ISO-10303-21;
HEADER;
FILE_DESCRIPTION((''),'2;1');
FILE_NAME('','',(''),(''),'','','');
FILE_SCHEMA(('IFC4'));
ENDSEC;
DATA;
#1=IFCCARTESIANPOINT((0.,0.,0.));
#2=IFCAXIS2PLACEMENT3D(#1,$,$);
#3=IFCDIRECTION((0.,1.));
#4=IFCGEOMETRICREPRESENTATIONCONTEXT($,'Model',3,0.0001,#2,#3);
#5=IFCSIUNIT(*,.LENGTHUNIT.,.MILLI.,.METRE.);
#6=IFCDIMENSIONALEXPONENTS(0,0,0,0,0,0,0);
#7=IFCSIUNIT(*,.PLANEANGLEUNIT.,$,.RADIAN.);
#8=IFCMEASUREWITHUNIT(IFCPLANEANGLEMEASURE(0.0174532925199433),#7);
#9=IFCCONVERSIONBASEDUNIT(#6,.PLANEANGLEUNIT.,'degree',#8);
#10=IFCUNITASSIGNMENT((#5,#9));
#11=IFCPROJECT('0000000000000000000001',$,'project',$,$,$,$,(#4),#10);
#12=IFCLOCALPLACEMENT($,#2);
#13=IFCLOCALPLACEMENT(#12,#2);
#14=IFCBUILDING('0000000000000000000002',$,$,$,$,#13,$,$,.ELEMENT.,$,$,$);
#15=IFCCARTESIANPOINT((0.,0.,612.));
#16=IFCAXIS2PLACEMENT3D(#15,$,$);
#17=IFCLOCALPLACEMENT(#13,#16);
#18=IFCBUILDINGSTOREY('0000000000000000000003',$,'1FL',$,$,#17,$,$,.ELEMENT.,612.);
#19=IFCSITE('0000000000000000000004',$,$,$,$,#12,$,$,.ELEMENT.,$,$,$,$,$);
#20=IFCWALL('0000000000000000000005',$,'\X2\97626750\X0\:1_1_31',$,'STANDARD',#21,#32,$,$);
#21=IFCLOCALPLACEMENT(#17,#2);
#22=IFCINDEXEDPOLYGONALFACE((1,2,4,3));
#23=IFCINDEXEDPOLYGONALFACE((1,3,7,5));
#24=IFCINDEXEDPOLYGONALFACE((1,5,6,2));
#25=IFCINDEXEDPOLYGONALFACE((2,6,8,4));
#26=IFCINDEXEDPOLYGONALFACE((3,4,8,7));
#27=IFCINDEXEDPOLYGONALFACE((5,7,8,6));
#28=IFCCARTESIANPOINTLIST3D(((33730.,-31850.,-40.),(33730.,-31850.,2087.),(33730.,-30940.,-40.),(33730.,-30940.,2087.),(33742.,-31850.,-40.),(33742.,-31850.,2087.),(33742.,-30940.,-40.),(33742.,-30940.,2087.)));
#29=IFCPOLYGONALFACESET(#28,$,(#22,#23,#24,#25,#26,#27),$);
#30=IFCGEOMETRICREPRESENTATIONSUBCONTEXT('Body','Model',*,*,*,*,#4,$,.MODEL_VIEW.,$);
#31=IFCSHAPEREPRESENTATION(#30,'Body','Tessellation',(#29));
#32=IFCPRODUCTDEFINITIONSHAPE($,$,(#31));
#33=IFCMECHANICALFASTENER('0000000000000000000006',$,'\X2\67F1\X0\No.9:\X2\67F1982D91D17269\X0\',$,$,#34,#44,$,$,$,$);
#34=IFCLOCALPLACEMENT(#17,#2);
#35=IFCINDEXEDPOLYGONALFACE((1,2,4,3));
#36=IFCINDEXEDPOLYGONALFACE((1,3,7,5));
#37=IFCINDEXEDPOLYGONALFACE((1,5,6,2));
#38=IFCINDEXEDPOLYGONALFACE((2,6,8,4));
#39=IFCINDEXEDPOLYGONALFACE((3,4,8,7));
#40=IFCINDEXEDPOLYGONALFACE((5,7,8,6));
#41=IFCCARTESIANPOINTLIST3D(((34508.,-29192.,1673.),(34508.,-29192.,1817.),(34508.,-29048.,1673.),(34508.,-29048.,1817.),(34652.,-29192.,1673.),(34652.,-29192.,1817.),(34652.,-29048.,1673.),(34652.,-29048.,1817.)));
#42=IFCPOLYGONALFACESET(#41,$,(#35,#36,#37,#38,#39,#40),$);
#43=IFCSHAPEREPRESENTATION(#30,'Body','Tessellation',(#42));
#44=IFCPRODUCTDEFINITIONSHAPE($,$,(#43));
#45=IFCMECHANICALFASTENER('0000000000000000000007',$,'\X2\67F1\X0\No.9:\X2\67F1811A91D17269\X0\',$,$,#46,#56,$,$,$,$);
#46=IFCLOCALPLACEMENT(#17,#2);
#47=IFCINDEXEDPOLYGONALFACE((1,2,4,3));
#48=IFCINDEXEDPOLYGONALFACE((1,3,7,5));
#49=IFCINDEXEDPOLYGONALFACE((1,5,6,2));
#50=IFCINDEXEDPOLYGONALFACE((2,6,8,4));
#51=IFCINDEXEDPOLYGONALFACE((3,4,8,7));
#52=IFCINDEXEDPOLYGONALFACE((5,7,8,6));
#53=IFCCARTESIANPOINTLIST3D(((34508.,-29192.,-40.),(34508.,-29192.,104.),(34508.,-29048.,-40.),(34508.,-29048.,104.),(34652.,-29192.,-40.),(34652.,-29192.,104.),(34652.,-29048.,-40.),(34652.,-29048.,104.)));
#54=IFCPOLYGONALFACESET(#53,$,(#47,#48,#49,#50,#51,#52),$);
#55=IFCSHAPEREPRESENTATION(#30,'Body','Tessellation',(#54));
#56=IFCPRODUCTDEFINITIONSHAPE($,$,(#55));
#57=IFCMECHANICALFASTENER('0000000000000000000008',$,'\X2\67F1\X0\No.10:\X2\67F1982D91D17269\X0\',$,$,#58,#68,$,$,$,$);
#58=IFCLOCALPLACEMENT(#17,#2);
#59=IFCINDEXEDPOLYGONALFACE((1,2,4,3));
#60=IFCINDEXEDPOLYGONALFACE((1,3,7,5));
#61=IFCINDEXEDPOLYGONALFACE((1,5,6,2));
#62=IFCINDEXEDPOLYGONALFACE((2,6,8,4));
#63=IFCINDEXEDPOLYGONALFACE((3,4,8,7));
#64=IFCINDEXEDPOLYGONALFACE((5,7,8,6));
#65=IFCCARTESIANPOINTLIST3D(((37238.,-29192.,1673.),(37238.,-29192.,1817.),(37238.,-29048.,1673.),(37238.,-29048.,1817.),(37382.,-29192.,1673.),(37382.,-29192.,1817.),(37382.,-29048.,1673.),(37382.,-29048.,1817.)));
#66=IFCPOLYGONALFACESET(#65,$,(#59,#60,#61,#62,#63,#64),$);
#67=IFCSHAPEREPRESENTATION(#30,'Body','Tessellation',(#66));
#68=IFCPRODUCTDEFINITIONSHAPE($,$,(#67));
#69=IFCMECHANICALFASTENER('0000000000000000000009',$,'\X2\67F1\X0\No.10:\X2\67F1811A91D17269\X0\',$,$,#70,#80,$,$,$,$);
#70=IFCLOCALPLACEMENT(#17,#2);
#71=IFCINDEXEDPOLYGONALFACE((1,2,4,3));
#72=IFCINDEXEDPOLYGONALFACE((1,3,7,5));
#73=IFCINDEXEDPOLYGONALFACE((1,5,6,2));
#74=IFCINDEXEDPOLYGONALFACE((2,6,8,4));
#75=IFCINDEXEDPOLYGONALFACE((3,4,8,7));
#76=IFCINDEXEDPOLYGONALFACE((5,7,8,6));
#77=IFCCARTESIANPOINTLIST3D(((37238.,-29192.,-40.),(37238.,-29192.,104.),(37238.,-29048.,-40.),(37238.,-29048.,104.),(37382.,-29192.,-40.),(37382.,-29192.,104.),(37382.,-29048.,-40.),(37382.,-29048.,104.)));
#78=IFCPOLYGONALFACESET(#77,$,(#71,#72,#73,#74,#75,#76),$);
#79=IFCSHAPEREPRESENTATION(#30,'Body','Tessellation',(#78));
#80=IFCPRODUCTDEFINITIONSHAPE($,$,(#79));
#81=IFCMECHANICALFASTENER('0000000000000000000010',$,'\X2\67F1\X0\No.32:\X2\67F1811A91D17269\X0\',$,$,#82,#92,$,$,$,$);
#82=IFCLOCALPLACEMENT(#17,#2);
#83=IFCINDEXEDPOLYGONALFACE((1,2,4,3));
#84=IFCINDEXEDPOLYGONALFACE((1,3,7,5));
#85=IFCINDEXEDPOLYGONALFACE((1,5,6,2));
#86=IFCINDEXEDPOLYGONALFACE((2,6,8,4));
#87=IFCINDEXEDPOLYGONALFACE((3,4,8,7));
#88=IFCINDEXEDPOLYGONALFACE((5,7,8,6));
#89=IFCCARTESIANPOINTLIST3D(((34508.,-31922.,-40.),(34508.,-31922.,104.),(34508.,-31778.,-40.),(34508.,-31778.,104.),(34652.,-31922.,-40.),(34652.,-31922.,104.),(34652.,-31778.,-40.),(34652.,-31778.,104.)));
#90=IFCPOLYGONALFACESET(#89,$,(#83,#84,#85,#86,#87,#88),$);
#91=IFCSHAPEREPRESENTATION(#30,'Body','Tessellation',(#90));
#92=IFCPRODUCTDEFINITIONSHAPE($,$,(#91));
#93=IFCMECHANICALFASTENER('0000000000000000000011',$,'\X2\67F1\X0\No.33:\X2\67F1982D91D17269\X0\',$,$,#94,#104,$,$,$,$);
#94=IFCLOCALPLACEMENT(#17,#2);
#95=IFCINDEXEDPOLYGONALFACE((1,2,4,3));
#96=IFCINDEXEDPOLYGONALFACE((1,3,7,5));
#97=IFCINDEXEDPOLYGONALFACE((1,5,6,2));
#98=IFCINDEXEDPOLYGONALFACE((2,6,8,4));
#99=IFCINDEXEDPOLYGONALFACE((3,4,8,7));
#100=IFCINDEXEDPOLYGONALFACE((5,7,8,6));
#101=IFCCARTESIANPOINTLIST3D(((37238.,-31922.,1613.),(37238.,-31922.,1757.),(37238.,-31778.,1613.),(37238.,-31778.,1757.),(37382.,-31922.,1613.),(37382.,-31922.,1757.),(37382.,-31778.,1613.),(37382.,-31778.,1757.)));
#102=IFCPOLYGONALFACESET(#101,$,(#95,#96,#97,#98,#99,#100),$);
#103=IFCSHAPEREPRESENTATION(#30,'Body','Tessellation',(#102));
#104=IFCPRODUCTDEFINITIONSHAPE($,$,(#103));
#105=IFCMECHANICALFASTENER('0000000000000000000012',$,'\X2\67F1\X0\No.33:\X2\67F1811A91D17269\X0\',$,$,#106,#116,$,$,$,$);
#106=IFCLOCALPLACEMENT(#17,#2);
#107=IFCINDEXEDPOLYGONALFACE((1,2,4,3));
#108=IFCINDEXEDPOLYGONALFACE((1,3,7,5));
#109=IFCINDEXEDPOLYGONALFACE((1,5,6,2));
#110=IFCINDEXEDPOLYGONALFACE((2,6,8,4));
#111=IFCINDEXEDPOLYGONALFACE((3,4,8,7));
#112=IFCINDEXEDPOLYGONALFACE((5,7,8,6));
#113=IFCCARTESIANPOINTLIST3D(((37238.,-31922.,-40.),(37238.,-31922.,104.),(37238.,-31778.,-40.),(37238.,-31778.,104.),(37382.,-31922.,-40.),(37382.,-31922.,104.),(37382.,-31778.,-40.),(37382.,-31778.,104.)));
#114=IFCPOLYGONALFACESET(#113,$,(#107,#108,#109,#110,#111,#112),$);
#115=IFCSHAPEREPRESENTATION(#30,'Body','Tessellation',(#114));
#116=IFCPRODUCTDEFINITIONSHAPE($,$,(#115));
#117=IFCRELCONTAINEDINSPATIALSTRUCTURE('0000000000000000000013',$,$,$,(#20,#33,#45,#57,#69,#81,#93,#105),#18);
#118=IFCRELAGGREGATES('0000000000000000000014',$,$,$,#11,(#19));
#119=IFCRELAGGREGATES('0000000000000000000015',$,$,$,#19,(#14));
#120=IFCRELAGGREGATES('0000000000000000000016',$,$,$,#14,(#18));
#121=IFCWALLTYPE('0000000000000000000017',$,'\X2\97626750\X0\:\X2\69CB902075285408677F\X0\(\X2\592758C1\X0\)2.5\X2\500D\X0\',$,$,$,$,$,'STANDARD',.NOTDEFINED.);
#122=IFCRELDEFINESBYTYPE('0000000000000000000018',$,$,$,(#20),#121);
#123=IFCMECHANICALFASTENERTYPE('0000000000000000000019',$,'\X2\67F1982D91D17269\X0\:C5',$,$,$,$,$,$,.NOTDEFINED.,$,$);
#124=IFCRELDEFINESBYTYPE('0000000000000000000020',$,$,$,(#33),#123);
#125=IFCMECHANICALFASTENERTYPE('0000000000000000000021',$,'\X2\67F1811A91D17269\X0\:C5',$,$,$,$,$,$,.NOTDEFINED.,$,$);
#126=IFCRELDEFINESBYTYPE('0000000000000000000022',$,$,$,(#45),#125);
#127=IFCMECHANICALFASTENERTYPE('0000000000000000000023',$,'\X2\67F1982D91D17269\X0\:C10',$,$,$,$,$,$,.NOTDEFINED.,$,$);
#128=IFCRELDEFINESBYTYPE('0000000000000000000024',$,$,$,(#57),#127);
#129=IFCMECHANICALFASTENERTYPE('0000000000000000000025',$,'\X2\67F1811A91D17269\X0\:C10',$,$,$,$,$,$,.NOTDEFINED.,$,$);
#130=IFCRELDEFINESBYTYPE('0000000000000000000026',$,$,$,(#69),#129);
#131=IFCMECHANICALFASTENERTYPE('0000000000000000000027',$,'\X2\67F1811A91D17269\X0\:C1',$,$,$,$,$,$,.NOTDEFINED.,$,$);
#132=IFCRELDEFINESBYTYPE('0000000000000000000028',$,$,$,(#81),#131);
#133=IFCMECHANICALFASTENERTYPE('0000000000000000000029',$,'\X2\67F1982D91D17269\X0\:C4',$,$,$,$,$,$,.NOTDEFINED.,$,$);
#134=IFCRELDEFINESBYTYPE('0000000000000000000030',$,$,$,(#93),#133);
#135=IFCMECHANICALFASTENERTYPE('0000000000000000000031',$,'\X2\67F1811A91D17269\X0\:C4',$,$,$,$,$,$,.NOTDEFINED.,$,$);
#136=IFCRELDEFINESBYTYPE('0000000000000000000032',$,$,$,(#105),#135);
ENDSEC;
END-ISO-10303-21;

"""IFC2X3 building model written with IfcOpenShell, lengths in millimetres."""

from ifc_helpers import new_model, entity, si_unit, converted_unit, direction, frame, origin, origin_with_axes, origin_2d, place, context, subcontext, project, spatial, polyline, rectangle, outline, extrude, type_object, element, save


model = new_model("IFC2X3")

# Units and contexts
model_context = context("Model", 3, precision=0.0001, world=origin(), true_north=direction((0.0, 1.0)))
body_context = subcontext(model_context, "Body", "Model", "MODEL_VIEW")
ifc_project = project(units=[si_unit("LENGTHUNIT", "METRE", prefix="MILLI"), converted_unit("PLANEANGLEUNIT", "degree", entity("IfcPlaneAngleMeasure", 0.0174532925199433), si_unit("PLANEANGLEUNIT", "RADIAN"), dimensions=[0, 0, 0, 0, 0, 0, 0])], contexts=[model_context])

# Site, building, storey
site_placement = place(None, origin())
site = spatial("IfcSite", under=ifc_project, at=site_placement, CompositionType="ELEMENT")
building_placement = place(site_placement, origin())
building = spatial("IfcBuilding", under=site, at=building_placement, CompositionType="ELEMENT")
storey_placement = place(building_placement, frame((0.0, 0.0, 612.0)))
storey = spatial("IfcBuildingStorey", under=building, at=storey_placement, Name="1FL", CompositionType="ELEMENT", Elevation=612.0)

# Wall
wall_type_1 = type_object("IfcWallType", Name="面材:構造用合板(大壁)2.5倍", ElementType="STANDARD", PredefinedType="NOTDEFINED")
wall_1_placement = place(storey_placement, frame((33742.0, -31395.0, -40.0), z_axis=(-1.0, 0.0, 0.0), x_axis=(0.0, -1.0, 0.0)))
element("IfcWall", 1, at=wall_1_placement, inside=storey, type_object=wall_type_1, Name="面材:1_1_31", ObjectType="STANDARD", context=body_context, shape_type="SweptSolid", body=[
    extrude(outline(polyline([(455.0, 0.0, 0.0), (-455.0, 0.0, 0.0), (-455.0, 2127.0, 0.0), (455.0, 2127.0, 0.0), (455.0, 0.0, 0.0)])), origin_with_axes(), (0.0, 0.0, 1.0), 12.0),
])

# Mechanical fasteners
mechanical_fastener_type_1 = type_object("IfcMechanicalFastenerType", Name="柱頭金物:C5")
mechanical_fastener_1_placement = place(storey_placement, frame((34580.0, -29120.0, 1673.0)))
element("IfcMechanicalFastener", 2, at=mechanical_fastener_1_placement, inside=storey, type_object=mechanical_fastener_type_1, Name="柱No.9:柱頭金物", context=body_context, shape_type="SweptSolid", body=[
    extrude(rectangle(XDim=144.0, YDim=144.0, at=origin_2d()), origin_with_axes(), (0.0, 0.0, 1.0), 144.0),
])
mechanical_fastener_type_2 = type_object("IfcMechanicalFastenerType", Name="柱脚金物:C5")
mechanical_fastener_2_placement = place(storey_placement, frame((34580.0, -29120.0, -40.0)))
element("IfcMechanicalFastener", 3, at=mechanical_fastener_2_placement, inside=storey, type_object=mechanical_fastener_type_2, Name="柱No.9:柱脚金物", context=body_context, shape_type="SweptSolid", body=[
    extrude(rectangle(XDim=144.0, YDim=144.0, at=origin_2d()), origin_with_axes(), (0.0, 0.0, 1.0), 144.0),
])
mechanical_fastener_type_3 = type_object("IfcMechanicalFastenerType", Name="柱頭金物:C10")
mechanical_fastener_3_placement = place(storey_placement, frame((37310.0, -29120.0, 1673.0)))
element("IfcMechanicalFastener", 4, at=mechanical_fastener_3_placement, inside=storey, type_object=mechanical_fastener_type_3, Name="柱No.10:柱頭金物", context=body_context, shape_type="SweptSolid", body=[
    extrude(rectangle(XDim=144.0, YDim=144.0, at=origin_2d()), origin_with_axes(), (0.0, 0.0, 1.0), 144.0),
])
mechanical_fastener_type_4 = type_object("IfcMechanicalFastenerType", Name="柱脚金物:C10")
mechanical_fastener_4_placement = place(storey_placement, frame((37310.0, -29120.0, -40.0)))
element("IfcMechanicalFastener", 5, at=mechanical_fastener_4_placement, inside=storey, type_object=mechanical_fastener_type_4, Name="柱No.10:柱脚金物", context=body_context, shape_type="SweptSolid", body=[
    extrude(rectangle(XDim=144.0, YDim=144.0, at=origin_2d()), origin_with_axes(), (0.0, 0.0, 1.0), 144.0),
])
mechanical_fastener_type_5 = type_object("IfcMechanicalFastenerType", Name="柱脚金物:C1")
mechanical_fastener_5_placement = place(storey_placement, frame((34580.0, -31850.0, -40.0)))
element("IfcMechanicalFastener", 6, at=mechanical_fastener_5_placement, inside=storey, type_object=mechanical_fastener_type_5, Name="柱No.32:柱脚金物", context=body_context, shape_type="SweptSolid", body=[
    extrude(rectangle(XDim=144.0, YDim=144.0, at=origin_2d()), origin_with_axes(), (0.0, 0.0, 1.0), 144.0),
])
mechanical_fastener_type_6 = type_object("IfcMechanicalFastenerType", Name="柱頭金物:C4")
mechanical_fastener_6_placement = place(storey_placement, frame((37310.0, -31850.0, 1613.0)))
element("IfcMechanicalFastener", 7, at=mechanical_fastener_6_placement, inside=storey, type_object=mechanical_fastener_type_6, Name="柱No.33:柱頭金物", context=body_context, shape_type="SweptSolid", body=[
    extrude(rectangle(XDim=144.0, YDim=144.0, at=origin_2d()), origin_with_axes(), (0.0, 0.0, 1.0), 144.0),
])
mechanical_fastener_type_7 = type_object("IfcMechanicalFastenerType", Name="柱脚金物:C4")
mechanical_fastener_7_placement = place(storey_placement, frame((37310.0, -31850.0, -40.0)))
element("IfcMechanicalFastener", 8, at=mechanical_fastener_7_placement, inside=storey, type_object=mechanical_fastener_type_7, Name="柱No.33:柱脚金物", context=body_context, shape_type="SweptSolid", body=[
    extrude(rectangle(XDim=144.0, YDim=144.0, at=origin_2d()), origin_with_axes(), (0.0, 0.0, 1.0), 144.0),
])

save(model, "model.ifc")
